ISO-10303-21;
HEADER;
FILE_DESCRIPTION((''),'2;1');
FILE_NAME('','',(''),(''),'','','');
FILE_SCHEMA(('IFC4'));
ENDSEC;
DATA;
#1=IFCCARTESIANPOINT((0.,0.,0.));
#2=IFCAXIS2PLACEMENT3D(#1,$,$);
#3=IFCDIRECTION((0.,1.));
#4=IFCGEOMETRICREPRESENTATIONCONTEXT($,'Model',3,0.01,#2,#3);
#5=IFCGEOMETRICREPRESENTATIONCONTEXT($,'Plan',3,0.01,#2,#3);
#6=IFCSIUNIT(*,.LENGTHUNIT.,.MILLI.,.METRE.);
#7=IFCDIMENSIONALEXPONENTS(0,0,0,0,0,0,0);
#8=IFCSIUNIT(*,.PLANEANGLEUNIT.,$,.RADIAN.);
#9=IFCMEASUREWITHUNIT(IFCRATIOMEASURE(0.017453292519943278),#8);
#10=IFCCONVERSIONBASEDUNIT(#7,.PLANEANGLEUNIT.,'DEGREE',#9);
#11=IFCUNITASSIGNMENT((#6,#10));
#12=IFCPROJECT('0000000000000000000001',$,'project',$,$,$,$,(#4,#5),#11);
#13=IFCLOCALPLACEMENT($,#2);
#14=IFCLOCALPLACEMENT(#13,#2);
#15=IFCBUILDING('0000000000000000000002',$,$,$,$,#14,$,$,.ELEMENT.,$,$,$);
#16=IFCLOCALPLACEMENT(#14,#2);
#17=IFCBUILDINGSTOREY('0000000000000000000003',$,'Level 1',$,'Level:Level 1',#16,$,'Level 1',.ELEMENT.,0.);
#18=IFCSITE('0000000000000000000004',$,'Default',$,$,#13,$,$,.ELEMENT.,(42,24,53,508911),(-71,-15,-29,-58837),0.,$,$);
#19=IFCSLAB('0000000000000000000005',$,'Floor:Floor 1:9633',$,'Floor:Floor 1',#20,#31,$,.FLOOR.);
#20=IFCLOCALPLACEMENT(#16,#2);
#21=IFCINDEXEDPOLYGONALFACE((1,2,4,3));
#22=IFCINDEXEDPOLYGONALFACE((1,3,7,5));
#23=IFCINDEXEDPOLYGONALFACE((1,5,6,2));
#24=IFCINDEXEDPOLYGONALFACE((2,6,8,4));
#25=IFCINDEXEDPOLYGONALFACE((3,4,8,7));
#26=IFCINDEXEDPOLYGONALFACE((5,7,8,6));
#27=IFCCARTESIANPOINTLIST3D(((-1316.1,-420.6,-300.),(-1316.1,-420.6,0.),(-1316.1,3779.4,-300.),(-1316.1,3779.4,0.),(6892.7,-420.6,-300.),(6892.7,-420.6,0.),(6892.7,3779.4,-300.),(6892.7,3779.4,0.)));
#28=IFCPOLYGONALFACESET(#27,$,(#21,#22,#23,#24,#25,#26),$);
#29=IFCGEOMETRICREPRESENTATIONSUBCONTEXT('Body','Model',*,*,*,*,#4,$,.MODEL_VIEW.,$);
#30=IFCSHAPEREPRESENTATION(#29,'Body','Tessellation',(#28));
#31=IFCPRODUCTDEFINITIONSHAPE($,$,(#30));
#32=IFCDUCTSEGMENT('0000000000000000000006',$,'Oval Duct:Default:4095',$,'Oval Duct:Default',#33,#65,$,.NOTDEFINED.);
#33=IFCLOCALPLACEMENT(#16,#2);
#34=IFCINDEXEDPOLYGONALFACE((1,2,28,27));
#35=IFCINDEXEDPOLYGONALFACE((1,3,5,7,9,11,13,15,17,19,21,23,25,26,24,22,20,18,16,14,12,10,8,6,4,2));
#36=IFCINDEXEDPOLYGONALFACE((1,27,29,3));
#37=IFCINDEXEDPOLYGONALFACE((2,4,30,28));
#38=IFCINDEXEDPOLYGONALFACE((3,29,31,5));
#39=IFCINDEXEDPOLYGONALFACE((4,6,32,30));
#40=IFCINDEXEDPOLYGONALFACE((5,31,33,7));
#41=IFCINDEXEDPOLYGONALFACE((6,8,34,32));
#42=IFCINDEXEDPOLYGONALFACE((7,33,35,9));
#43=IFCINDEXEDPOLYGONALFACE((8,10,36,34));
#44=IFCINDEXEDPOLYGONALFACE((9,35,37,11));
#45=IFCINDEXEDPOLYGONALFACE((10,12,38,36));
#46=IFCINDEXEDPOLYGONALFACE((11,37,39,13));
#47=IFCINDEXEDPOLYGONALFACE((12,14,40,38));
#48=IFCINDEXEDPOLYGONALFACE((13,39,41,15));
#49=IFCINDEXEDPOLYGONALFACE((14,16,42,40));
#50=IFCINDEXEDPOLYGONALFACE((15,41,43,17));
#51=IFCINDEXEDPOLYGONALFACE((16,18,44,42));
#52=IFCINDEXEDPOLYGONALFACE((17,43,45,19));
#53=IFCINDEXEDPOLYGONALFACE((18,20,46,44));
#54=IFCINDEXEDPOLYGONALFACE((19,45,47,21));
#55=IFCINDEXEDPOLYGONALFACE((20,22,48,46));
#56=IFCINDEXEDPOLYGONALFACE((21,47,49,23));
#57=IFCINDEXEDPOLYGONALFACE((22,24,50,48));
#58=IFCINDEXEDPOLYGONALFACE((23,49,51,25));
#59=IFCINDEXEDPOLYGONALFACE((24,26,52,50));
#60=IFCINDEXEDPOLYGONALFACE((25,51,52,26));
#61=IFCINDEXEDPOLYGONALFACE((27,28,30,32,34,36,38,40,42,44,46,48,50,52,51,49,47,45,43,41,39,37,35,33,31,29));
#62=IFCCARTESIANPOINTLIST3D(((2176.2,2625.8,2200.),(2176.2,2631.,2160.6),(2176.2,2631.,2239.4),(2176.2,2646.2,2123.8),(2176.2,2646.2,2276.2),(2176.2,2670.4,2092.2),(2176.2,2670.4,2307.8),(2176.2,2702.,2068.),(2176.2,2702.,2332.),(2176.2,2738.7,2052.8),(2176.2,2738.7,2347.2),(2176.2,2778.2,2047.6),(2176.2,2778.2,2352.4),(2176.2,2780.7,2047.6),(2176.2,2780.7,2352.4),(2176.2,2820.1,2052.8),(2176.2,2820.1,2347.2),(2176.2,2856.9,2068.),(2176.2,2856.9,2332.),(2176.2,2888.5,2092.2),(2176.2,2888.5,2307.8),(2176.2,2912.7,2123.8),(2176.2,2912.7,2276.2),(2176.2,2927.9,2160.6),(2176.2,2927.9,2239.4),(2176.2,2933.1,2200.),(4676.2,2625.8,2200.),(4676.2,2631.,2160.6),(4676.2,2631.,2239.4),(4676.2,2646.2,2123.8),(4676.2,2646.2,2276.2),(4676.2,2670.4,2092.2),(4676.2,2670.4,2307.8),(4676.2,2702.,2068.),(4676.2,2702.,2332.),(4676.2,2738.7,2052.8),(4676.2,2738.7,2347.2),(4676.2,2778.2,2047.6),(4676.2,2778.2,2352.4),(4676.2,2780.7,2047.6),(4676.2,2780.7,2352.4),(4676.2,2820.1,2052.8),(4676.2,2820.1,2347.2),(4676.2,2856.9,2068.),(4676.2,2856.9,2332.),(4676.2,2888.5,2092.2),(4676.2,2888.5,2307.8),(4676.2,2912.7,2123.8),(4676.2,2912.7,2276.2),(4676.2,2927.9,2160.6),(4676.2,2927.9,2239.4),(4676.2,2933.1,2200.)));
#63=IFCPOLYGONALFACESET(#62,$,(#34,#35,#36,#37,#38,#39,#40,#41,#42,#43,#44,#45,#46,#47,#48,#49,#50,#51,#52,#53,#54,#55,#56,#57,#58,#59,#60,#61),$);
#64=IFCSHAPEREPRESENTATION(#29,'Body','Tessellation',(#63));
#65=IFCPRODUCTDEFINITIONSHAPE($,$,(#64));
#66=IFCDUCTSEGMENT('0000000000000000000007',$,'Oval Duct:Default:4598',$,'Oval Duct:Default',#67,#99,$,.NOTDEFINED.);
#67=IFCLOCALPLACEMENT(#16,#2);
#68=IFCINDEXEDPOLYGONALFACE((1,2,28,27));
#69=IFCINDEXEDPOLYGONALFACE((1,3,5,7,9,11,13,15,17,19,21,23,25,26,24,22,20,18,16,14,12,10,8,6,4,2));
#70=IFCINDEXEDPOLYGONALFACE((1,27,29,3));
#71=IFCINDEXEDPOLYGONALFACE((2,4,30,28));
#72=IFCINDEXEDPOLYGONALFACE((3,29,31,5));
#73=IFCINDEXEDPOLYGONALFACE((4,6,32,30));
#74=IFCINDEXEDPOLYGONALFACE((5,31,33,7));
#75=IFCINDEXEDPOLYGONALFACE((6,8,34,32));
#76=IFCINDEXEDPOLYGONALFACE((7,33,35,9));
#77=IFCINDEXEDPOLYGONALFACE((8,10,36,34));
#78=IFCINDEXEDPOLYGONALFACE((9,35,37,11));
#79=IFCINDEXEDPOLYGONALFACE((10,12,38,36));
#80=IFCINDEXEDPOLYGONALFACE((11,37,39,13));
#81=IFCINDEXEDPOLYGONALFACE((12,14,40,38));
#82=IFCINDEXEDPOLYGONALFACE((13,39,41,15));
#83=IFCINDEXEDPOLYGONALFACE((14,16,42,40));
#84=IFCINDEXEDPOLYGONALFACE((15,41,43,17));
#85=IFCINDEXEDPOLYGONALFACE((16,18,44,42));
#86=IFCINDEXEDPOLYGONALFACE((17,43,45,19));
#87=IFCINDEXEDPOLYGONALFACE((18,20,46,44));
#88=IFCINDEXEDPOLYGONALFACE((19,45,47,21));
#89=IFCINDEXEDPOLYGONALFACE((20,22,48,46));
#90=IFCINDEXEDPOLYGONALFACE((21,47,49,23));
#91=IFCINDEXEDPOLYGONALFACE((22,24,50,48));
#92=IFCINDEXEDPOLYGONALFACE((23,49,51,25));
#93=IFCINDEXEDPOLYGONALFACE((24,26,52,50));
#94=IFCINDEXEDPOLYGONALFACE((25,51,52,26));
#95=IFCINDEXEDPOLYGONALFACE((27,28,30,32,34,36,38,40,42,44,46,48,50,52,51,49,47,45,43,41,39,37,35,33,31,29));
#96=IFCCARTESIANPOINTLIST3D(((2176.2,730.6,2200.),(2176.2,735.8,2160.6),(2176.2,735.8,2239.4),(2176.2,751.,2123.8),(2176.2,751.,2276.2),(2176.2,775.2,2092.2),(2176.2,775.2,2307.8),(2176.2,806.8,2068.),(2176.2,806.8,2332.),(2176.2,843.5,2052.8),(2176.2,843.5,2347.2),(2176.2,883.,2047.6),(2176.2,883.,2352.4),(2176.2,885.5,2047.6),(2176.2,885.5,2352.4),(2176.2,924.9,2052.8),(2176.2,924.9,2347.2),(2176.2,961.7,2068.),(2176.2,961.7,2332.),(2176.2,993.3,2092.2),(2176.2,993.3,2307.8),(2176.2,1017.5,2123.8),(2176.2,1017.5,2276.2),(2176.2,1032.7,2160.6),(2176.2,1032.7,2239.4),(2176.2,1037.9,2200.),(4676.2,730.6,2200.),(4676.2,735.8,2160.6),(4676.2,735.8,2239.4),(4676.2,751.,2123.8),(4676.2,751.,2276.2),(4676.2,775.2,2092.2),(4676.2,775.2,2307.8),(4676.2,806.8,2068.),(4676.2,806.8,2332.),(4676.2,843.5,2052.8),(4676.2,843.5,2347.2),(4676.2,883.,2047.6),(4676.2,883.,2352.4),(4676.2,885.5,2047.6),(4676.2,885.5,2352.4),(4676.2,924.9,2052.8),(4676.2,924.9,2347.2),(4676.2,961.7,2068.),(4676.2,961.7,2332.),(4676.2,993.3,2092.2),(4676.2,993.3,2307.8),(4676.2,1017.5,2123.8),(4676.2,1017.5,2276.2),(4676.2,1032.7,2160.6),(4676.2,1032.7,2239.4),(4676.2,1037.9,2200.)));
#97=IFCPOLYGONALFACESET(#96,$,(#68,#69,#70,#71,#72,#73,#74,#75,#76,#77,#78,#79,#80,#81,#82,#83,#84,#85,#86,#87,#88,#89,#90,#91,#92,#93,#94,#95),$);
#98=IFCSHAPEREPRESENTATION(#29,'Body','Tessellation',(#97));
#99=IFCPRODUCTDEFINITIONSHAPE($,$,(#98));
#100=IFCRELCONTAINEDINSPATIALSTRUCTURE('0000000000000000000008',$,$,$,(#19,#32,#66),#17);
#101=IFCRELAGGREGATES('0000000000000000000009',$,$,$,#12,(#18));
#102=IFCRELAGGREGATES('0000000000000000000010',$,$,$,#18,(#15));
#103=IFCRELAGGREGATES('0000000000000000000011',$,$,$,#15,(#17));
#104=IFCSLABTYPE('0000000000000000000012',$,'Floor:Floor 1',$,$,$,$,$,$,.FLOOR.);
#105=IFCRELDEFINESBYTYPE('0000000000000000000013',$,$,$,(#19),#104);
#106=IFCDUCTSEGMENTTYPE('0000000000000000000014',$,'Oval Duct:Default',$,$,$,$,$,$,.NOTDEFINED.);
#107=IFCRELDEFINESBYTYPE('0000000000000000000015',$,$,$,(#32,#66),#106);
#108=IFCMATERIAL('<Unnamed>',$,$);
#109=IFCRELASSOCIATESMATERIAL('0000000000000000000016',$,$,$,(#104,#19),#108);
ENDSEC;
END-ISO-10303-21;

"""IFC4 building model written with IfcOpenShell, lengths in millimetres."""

from ifc_helpers import new_model, entity, si_unit, converted_unit, direction, frame, origin, place, context, subcontext, project, spatial, line, arc, indexed_curve, outline, extrude, material, type_object, element, save


model = new_model("IFC4")

# Units and contexts
model_context = context("Model", 3, precision=0.01, world=origin(), true_north=direction((0.0, 1.0)))
plan_context = context("Plan", 3, precision=0.01, world=origin(), true_north=direction((0.0, 1.0)))
body_context = subcontext(model_context, "Body", "Model", "MODEL_VIEW")
ifc_project = project(units=[si_unit("LENGTHUNIT", "METRE", prefix="MILLI"), converted_unit("PLANEANGLEUNIT", "DEGREE", entity("IfcRatioMeasure", 0.017453292519943278), si_unit("PLANEANGLEUNIT", "RADIAN"), dimensions=[0, 0, 0, 0, 0, 0, 0])], contexts=[model_context, plan_context])

# Site, building, storey
site_placement = place(None, origin())
site = spatial("IfcSite", under=ifc_project, at=site_placement, Name="Default", CompositionType="ELEMENT", RefLatitude=(42, 24, 53, 508911), RefLongitude=(-71, -15, -29, -58837), RefElevation=0.0)
building_placement = place(site_placement, origin())
building = spatial("IfcBuilding", under=site, at=building_placement, CompositionType="ELEMENT")
storey_placement = place(building_placement, origin())
storey = spatial("IfcBuildingStorey", under=building, at=storey_placement, Name="Level 1", ObjectType="Level:Level 1", LongName="Level 1", CompositionType="ELEMENT", Elevation=0.0)

# Slab
ifc_material_1 = material(Name="<Unnamed>")
slab_type = type_object("IfcSlabType", Name="Floor:Floor 1", PredefinedType="FLOOR", material=ifc_material_1)
slab_placement = place(storey_placement, origin())
element("IfcSlab", 1, at=slab_placement, inside=storey, type_object=slab_type, material=ifc_material_1, Name="Floor:Floor 1:9633", ObjectType="Floor:Floor 1", PredefinedType="FLOOR", context=body_context, shape_type="SweptSolid", body=[
    extrude(outline(indexed_curve([(-2100.0, -4104.4), (2100.0, -4104.4), (2100.0, 4104.4), (-2100.0, 4104.4), (-2100.0, -4104.4)], self_intersect=False)), frame((2788.3, 1679.4, 0.0), z_axis=(0.0, 0.0, -1.0), x_axis=(0.0, 1.0, 0.0)), (0.0, 0.0, 1.0), 300.0),
])

# Duct segments
duct_segment_type = type_object("IfcDuctSegmentType", Name="Oval Duct:Default", PredefinedType="NOTDEFINED")
duct_segment_1_placement = place(storey_placement, origin())
element("IfcDuctSegment", 2, at=duct_segment_1_placement, inside=storey, type_object=duct_segment_type, Name="Oval Duct:Default:4095", ObjectType="Oval Duct:Default", PredefinedType="NOTDEFINED", context=body_context, shape_type="SweptSolid", body=[
    extrude(outline(indexed_curve([(-1.3, -152.4), (1.3, -152.4), (109.0, -107.8), (153.7, 0.0), (109.0, 107.8), (1.3, 152.4), (-1.3, 152.4), (-109.0, 107.8), (-153.7, 0.0), (-109.0, -107.8)], segments=[line(1, 2), arc(2, 3, 4), arc(4, 5, 6), line(6, 7), arc(7, 8, 9), arc(9, 10, 1)], self_intersect=False)), frame((2176.2, 2779.4, 2200.0), z_axis=(1.0, 0.0, 0.0), x_axis=(0.0, -1.0, 0.0)), (0.0, 0.0, 1.0), 2500.0),
])
duct_segment_2_placement = place(storey_placement, origin())
element("IfcDuctSegment", 3, at=duct_segment_2_placement, inside=storey, type_object=duct_segment_type, Name="Oval Duct:Default:4598", ObjectType="Oval Duct:Default", PredefinedType="NOTDEFINED", context=body_context, shape_type="SweptSolid", body=[
    extrude(outline(indexed_curve([(-1.3, -152.4), (1.3, -152.4), (109.0, -107.8), (153.7, 0.0), (109.0, 107.8), (1.3, 152.4), (-1.3, 152.4), (-109.0, 107.8), (-153.7, 0.0), (-109.0, -107.8)], segments=[line(1, 2), arc(2, 3, 4), arc(4, 5, 6), line(6, 7), arc(7, 8, 9), arc(9, 10, 1)], self_intersect=False)), frame((2176.2, 884.2, 2200.0), z_axis=(1.0, 0.0, 0.0), x_axis=(0.0, -1.0, 0.0)), (0.0, 0.0, 1.0), 2500.0),
])

save(model, "model.ifc")
